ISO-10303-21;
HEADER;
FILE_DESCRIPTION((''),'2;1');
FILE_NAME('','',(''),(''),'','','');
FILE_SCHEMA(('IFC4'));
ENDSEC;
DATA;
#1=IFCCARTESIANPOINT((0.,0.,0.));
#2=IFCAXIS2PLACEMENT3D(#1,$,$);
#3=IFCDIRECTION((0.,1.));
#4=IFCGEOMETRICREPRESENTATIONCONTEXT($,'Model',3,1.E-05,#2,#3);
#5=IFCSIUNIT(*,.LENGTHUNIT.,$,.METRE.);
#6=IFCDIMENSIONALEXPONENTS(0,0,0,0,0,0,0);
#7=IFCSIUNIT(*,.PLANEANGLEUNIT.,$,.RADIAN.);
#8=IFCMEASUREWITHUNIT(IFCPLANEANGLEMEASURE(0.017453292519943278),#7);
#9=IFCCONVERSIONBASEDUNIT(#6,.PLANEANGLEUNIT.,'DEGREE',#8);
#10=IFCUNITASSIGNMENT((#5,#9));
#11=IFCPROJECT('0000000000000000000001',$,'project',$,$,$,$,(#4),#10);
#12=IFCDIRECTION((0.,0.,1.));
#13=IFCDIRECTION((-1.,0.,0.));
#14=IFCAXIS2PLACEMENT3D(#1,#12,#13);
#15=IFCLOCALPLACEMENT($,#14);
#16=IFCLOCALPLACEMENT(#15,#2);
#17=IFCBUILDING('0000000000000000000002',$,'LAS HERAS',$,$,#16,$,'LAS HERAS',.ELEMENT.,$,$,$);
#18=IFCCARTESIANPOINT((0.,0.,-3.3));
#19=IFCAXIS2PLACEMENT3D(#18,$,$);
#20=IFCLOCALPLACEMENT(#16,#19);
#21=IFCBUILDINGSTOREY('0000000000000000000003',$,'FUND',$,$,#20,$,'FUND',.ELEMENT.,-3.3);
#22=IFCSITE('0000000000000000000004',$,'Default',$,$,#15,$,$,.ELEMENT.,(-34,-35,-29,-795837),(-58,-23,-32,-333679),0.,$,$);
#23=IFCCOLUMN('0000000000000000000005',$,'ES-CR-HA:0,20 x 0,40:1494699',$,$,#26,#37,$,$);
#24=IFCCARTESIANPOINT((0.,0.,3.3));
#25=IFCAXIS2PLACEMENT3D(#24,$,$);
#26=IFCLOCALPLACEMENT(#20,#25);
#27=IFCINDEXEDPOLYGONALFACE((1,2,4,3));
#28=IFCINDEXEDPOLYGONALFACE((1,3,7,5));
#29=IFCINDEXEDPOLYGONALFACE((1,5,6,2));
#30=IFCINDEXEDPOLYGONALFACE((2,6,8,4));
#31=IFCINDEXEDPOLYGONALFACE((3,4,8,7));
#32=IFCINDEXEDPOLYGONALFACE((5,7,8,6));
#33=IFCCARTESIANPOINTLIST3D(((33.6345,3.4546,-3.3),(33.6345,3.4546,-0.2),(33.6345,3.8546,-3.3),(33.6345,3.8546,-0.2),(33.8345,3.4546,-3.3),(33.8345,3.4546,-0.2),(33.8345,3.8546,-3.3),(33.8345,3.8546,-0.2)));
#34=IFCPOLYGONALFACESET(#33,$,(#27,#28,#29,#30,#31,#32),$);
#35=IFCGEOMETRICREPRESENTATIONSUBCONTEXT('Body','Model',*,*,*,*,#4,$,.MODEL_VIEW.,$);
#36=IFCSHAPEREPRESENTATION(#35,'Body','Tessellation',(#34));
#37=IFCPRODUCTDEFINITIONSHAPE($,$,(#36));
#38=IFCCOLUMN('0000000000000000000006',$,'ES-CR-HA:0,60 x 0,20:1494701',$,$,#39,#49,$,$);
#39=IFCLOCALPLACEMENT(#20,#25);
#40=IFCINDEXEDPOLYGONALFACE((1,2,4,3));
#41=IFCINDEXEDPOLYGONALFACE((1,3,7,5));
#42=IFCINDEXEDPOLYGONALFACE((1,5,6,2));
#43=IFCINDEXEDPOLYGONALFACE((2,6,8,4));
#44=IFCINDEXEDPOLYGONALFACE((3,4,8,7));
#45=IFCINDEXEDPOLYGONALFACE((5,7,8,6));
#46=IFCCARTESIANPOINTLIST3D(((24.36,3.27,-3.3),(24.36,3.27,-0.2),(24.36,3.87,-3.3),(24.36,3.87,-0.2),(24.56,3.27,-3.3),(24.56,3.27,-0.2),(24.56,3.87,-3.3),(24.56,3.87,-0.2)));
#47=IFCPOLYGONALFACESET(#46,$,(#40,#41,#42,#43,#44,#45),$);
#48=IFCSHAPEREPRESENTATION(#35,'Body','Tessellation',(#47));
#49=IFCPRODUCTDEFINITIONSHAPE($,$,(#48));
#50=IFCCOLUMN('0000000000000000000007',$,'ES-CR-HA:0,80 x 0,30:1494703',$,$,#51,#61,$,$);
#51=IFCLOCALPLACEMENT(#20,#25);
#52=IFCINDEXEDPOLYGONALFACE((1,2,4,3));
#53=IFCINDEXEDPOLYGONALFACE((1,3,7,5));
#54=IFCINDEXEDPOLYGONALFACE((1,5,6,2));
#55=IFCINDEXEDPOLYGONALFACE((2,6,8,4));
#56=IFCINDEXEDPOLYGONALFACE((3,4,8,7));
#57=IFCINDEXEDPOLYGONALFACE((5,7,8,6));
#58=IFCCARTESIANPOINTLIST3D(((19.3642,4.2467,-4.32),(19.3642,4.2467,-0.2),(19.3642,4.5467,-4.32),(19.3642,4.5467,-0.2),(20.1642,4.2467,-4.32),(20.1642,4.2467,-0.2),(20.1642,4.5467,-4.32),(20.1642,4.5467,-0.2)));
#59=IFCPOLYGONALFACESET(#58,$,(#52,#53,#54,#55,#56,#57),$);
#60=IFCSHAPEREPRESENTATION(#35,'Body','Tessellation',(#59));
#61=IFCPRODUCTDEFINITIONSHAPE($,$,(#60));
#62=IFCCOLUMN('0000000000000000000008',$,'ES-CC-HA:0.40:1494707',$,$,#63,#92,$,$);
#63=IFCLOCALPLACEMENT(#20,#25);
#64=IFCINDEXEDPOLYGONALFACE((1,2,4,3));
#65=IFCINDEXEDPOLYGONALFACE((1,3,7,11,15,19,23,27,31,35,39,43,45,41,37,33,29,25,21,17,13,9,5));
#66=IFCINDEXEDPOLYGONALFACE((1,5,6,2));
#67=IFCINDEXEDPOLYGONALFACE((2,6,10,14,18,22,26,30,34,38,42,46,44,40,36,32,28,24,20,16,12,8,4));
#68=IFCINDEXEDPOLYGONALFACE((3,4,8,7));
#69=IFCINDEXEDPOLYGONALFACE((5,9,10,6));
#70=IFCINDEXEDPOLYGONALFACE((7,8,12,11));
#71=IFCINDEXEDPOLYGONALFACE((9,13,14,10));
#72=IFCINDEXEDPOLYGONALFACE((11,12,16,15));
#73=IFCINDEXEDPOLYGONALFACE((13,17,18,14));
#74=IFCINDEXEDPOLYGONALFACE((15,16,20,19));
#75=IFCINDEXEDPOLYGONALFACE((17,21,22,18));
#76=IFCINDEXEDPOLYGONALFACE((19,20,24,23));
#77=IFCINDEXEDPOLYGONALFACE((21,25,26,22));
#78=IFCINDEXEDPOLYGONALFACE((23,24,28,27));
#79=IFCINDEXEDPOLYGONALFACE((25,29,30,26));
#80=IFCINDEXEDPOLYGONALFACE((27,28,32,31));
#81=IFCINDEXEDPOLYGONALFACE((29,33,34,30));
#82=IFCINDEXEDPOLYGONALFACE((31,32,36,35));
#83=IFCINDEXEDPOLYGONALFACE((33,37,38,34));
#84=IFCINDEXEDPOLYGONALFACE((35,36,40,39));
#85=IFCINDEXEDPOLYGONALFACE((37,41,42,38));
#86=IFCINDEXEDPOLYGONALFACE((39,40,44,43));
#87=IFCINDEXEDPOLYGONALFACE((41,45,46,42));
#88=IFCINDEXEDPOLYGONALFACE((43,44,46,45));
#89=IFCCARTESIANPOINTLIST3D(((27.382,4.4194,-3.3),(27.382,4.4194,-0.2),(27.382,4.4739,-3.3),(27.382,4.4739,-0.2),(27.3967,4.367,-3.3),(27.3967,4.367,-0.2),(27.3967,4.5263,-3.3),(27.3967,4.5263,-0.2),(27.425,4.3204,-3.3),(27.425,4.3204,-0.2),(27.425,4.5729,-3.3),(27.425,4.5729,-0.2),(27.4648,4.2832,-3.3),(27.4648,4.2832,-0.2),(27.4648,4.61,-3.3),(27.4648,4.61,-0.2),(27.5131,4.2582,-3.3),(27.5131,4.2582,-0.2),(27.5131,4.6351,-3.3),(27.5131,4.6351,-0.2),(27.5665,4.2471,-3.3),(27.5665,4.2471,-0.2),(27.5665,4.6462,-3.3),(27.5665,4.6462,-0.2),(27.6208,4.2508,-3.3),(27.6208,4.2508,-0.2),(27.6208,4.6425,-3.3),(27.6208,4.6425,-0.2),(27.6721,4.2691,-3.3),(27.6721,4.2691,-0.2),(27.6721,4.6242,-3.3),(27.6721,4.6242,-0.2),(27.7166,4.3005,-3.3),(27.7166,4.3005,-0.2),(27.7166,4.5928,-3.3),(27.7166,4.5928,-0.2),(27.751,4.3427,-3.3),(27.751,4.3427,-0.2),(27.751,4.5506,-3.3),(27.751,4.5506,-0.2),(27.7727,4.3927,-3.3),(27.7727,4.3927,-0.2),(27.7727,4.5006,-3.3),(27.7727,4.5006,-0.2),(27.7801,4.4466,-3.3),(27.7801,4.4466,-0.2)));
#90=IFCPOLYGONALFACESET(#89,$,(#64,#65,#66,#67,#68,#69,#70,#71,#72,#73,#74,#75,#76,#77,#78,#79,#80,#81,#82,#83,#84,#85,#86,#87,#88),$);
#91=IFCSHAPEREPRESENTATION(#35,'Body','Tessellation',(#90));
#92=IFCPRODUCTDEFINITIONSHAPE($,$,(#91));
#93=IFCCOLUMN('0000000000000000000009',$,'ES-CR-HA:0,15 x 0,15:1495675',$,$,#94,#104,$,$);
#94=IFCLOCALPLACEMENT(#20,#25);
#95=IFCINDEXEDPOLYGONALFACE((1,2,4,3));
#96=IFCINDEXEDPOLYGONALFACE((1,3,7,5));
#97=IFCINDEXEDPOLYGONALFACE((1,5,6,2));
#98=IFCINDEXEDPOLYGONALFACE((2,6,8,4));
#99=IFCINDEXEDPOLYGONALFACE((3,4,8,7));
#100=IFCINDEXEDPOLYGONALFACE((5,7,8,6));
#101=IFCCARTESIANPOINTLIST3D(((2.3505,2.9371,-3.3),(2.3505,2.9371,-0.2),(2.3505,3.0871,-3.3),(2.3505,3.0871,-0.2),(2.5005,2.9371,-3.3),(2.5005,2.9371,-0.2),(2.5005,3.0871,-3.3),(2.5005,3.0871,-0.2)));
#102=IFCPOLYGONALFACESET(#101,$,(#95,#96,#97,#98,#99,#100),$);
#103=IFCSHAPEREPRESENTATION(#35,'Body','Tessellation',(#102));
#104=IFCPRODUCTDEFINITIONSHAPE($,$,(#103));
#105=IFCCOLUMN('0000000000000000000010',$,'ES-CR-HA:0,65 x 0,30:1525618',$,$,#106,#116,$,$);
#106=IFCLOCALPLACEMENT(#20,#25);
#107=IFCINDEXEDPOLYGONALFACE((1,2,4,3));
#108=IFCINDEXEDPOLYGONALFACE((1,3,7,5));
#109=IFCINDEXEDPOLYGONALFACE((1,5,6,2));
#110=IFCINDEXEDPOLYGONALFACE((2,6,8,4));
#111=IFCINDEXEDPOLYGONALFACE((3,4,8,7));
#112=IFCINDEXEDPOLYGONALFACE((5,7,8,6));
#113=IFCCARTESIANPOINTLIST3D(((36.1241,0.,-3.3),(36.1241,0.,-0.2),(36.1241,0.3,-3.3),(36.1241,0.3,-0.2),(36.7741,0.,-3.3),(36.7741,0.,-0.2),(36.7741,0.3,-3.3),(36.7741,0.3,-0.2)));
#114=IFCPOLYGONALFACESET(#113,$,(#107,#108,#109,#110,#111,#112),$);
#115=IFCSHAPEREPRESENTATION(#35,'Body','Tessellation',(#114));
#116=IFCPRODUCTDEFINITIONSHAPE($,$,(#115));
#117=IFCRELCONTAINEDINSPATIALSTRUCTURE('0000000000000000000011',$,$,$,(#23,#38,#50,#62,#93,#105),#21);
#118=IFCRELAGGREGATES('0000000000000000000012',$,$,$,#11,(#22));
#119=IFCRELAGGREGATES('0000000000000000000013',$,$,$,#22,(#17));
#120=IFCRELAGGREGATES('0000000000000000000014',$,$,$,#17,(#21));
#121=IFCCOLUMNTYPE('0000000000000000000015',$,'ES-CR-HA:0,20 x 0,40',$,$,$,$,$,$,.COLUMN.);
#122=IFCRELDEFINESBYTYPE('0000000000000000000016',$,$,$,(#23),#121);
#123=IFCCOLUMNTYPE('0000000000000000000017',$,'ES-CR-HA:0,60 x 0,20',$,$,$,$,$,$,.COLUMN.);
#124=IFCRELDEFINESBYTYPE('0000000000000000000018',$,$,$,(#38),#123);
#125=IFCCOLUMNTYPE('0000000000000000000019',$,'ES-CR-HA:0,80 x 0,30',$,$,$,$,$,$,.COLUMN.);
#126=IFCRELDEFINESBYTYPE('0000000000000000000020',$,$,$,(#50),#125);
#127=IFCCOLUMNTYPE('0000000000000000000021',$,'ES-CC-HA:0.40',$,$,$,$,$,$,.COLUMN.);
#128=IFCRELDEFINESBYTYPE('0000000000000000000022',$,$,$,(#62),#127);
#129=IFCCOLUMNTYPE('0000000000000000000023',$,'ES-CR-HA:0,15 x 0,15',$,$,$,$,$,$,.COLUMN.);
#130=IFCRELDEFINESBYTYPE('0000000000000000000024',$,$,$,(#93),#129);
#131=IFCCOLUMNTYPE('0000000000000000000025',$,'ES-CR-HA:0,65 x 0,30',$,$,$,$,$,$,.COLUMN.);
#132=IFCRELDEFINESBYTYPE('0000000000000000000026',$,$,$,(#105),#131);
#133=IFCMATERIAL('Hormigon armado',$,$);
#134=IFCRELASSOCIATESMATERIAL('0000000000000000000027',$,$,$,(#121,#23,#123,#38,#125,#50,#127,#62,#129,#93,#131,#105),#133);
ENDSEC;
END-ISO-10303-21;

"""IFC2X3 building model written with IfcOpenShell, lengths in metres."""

from ifc_helpers import new_model, entity, si_unit, converted_unit, direction, frame, frame_2d, origin, origin_2d_with_axis, place, context, subcontext, project, spatial, rectangle, circle, extrude, source, transform, mapped, material, type_object, type_shapes, element, save


model = new_model("IFC2X3")

# Units and contexts
model_context = context("Model", 3, precision=1e-05, world=origin(), true_north=direction((0.0, 1.0)))
body_context = subcontext(model_context, "Body", "Model", "MODEL_VIEW")
ifc_project = project(units=[si_unit("LENGTHUNIT", "METRE"), converted_unit("PLANEANGLEUNIT", "DEGREE", entity("IfcPlaneAngleMeasure", 0.017453292519943278), si_unit("PLANEANGLEUNIT", "RADIAN"), dimensions=[0, 0, 0, 0, 0, 0, 0])], contexts=[model_context])

# Site, building, storey
site_placement = place(None, frame((0.0, 0.0, 0.0), z_axis=(0.0, 0.0, 1.0), x_axis=(-1.0, 0.0, 0.0)))
site = spatial("IfcSite", under=ifc_project, at=site_placement, Name="Default", CompositionType="ELEMENT", RefLatitude=(-34, -35, -29, -795837), RefLongitude=(-58, -23, -32, -333679), RefElevation=0.0)
building_placement = place(site_placement, origin())
building = spatial("IfcBuilding", under=site, at=building_placement, Name="LAS HERAS", LongName="LAS HERAS", CompositionType="ELEMENT")
storey_placement = place(building_placement, frame((0.0, 0.0, -3.3)))
storey = spatial("IfcBuildingStorey", under=building, at=storey_placement, Name="FUND", LongName="FUND", CompositionType="ELEMENT", Elevation=-3.3)

# Columns
ifc_material = material(Name="Hormigon armado")
column_type_1 = type_object("IfcColumnType", Name="ES-CR-HA:0,20 x 0,40", PredefinedType="COLUMN", material=ifc_material)
shared_shape_1 = source(origin(), body_context, "Body", "SweptSolid", [
    extrude(rectangle(XDim=0.2, YDim=0.4, at=origin_2d_with_axis()), frame((33.7345, 3.6546, -3.3), z_axis=(0.0, 0.0, 1.0), x_axis=(-1.0, 0.0, 0.0)), (0.0, 0.0, 1.0), 3.1),
])
type_shapes(column_type_1, [shared_shape_1])
column_1_placement = place(storey_placement, frame((0.0, 0.0, 3.3)))
element("IfcColumn", 1, at=column_1_placement, inside=storey, type_object=column_type_1, material=ifc_material, Name="ES-CR-HA:0,20 x 0,40:1494699", context=body_context, shape_type="MappedRepresentation", body=[
    mapped(shared_shape_1, transform((0.0, 0.0, 0.0), scale=1.0)),
])
column_type_2 = type_object("IfcColumnType", Name="ES-CR-HA:0,60 x 0,20", PredefinedType="COLUMN", material=ifc_material)
shared_shape_2 = source(origin(), body_context, "Body", "SweptSolid", [
    extrude(rectangle(XDim=0.6, YDim=0.2, at=frame_2d((0.0, 0.0), x_axis=(1.0, 0.0))), frame((24.46, 3.57, -3.3), z_axis=(0.0, 0.0, 1.0), x_axis=(0.0, -1.0, 0.0)), (0.0, 0.0, 1.0), 3.1),
])
type_shapes(column_type_2, [shared_shape_2])
column_2_placement = place(storey_placement, frame((0.0, 0.0, 3.3)))
element("IfcColumn", 2, at=column_2_placement, inside=storey, type_object=column_type_2, material=ifc_material, Name="ES-CR-HA:0,60 x 0,20:1494701", context=body_context, shape_type="MappedRepresentation", body=[
    mapped(shared_shape_2, transform((0.0, 0.0, 0.0), scale=1.0)),
])
column_type_3 = type_object("IfcColumnType", Name="ES-CR-HA:0,80 x 0,30", PredefinedType="COLUMN", material=ifc_material)
shared_shape_3 = source(origin(), body_context, "Body", "SweptSolid", [
    extrude(rectangle(XDim=0.8, YDim=0.3, at=origin_2d_with_axis()), frame((19.7642, 4.3967, -4.32), z_axis=(0.0, 0.0, 1.0), x_axis=(-1.0, 0.0, 0.0)), (0.0, 0.0, 1.0), 4.12),
])
type_shapes(column_type_3, [shared_shape_3])
column_3_placement = place(storey_placement, frame((0.0, 0.0, 3.3)))
element("IfcColumn", 3, at=column_3_placement, inside=storey, type_object=column_type_3, material=ifc_material, Name="ES-CR-HA:0,80 x 0,30:1494703", context=body_context, shape_type="MappedRepresentation", body=[
    mapped(shared_shape_3, transform((0.0, 0.0, 0.0), scale=1.0)),
])
column_type_4 = type_object("IfcColumnType", Name="ES-CC-HA:0.40", PredefinedType="COLUMN", material=ifc_material)
shared_shape_4 = source(origin(), body_context, "Body", "SweptSolid", [
    extrude(circle(Radius=0.2, at=origin_2d_with_axis()), frame((27.5801, 4.4466, -3.3)), (0.0, 0.0, 1.0), 3.1),
])
type_shapes(column_type_4, [shared_shape_4])
column_4_placement = place(storey_placement, frame((0.0, 0.0, 3.3)))
element("IfcColumn", 4, at=column_4_placement, inside=storey, type_object=column_type_4, material=ifc_material, Name="ES-CC-HA:0.40:1494707", context=body_context, shape_type="MappedRepresentation", body=[
    mapped(shared_shape_4, transform((0.0, 0.0, 0.0), scale=1.0)),
])
column_type_5 = type_object("IfcColumnType", Name="ES-CR-HA:0,15 x 0,15", PredefinedType="COLUMN", material=ifc_material)
shared_shape_5 = source(origin(), body_context, "Body", "SweptSolid", [
    extrude(rectangle(XDim=0.15, YDim=0.15, at=frame_2d((0.0, 0.0), x_axis=(1.0, 0.0))), frame((2.4255, 3.0121, -3.3), z_axis=(0.0, 0.0, 1.0), x_axis=(-1.0, 0.0, 0.0)), (0.0, 0.0, 1.0), 3.1),
])
type_shapes(column_type_5, [shared_shape_5])
column_5_placement = place(storey_placement, frame((0.0, 0.0, 3.3)))
element("IfcColumn", 5, at=column_5_placement, inside=storey, type_object=column_type_5, material=ifc_material, Name="ES-CR-HA:0,15 x 0,15:1495675", context=body_context, shape_type="MappedRepresentation", body=[
    mapped(shared_shape_5, transform((0.0, 0.0, 0.0), scale=1.0)),
])
column_type_6 = type_object("IfcColumnType", Name="ES-CR-HA:0,65 x 0,30", PredefinedType="COLUMN", material=ifc_material)
shared_shape_6 = source(origin(), body_context, "Body", "SweptSolid", [
    extrude(rectangle(XDim=0.65, YDim=0.3, at=origin_2d_with_axis()), frame((36.4491, 0.15, -3.3), z_axis=(0.0, 0.0, 1.0), x_axis=(-1.0, 0.0, 0.0)), (0.0, 0.0, 1.0), 3.1),
])
type_shapes(column_type_6, [shared_shape_6])
column_6_placement = place(storey_placement, frame((0.0, 0.0, 3.3)))
element("IfcColumn", 6, at=column_6_placement, inside=storey, type_object=column_type_6, material=ifc_material, Name="ES-CR-HA:0,65 x 0,30:1525618", context=body_context, shape_type="MappedRepresentation", body=[
    mapped(shared_shape_6, transform((0.0, 0.0, 0.0), scale=1.0)),
])

save(model, "model.ifc")
